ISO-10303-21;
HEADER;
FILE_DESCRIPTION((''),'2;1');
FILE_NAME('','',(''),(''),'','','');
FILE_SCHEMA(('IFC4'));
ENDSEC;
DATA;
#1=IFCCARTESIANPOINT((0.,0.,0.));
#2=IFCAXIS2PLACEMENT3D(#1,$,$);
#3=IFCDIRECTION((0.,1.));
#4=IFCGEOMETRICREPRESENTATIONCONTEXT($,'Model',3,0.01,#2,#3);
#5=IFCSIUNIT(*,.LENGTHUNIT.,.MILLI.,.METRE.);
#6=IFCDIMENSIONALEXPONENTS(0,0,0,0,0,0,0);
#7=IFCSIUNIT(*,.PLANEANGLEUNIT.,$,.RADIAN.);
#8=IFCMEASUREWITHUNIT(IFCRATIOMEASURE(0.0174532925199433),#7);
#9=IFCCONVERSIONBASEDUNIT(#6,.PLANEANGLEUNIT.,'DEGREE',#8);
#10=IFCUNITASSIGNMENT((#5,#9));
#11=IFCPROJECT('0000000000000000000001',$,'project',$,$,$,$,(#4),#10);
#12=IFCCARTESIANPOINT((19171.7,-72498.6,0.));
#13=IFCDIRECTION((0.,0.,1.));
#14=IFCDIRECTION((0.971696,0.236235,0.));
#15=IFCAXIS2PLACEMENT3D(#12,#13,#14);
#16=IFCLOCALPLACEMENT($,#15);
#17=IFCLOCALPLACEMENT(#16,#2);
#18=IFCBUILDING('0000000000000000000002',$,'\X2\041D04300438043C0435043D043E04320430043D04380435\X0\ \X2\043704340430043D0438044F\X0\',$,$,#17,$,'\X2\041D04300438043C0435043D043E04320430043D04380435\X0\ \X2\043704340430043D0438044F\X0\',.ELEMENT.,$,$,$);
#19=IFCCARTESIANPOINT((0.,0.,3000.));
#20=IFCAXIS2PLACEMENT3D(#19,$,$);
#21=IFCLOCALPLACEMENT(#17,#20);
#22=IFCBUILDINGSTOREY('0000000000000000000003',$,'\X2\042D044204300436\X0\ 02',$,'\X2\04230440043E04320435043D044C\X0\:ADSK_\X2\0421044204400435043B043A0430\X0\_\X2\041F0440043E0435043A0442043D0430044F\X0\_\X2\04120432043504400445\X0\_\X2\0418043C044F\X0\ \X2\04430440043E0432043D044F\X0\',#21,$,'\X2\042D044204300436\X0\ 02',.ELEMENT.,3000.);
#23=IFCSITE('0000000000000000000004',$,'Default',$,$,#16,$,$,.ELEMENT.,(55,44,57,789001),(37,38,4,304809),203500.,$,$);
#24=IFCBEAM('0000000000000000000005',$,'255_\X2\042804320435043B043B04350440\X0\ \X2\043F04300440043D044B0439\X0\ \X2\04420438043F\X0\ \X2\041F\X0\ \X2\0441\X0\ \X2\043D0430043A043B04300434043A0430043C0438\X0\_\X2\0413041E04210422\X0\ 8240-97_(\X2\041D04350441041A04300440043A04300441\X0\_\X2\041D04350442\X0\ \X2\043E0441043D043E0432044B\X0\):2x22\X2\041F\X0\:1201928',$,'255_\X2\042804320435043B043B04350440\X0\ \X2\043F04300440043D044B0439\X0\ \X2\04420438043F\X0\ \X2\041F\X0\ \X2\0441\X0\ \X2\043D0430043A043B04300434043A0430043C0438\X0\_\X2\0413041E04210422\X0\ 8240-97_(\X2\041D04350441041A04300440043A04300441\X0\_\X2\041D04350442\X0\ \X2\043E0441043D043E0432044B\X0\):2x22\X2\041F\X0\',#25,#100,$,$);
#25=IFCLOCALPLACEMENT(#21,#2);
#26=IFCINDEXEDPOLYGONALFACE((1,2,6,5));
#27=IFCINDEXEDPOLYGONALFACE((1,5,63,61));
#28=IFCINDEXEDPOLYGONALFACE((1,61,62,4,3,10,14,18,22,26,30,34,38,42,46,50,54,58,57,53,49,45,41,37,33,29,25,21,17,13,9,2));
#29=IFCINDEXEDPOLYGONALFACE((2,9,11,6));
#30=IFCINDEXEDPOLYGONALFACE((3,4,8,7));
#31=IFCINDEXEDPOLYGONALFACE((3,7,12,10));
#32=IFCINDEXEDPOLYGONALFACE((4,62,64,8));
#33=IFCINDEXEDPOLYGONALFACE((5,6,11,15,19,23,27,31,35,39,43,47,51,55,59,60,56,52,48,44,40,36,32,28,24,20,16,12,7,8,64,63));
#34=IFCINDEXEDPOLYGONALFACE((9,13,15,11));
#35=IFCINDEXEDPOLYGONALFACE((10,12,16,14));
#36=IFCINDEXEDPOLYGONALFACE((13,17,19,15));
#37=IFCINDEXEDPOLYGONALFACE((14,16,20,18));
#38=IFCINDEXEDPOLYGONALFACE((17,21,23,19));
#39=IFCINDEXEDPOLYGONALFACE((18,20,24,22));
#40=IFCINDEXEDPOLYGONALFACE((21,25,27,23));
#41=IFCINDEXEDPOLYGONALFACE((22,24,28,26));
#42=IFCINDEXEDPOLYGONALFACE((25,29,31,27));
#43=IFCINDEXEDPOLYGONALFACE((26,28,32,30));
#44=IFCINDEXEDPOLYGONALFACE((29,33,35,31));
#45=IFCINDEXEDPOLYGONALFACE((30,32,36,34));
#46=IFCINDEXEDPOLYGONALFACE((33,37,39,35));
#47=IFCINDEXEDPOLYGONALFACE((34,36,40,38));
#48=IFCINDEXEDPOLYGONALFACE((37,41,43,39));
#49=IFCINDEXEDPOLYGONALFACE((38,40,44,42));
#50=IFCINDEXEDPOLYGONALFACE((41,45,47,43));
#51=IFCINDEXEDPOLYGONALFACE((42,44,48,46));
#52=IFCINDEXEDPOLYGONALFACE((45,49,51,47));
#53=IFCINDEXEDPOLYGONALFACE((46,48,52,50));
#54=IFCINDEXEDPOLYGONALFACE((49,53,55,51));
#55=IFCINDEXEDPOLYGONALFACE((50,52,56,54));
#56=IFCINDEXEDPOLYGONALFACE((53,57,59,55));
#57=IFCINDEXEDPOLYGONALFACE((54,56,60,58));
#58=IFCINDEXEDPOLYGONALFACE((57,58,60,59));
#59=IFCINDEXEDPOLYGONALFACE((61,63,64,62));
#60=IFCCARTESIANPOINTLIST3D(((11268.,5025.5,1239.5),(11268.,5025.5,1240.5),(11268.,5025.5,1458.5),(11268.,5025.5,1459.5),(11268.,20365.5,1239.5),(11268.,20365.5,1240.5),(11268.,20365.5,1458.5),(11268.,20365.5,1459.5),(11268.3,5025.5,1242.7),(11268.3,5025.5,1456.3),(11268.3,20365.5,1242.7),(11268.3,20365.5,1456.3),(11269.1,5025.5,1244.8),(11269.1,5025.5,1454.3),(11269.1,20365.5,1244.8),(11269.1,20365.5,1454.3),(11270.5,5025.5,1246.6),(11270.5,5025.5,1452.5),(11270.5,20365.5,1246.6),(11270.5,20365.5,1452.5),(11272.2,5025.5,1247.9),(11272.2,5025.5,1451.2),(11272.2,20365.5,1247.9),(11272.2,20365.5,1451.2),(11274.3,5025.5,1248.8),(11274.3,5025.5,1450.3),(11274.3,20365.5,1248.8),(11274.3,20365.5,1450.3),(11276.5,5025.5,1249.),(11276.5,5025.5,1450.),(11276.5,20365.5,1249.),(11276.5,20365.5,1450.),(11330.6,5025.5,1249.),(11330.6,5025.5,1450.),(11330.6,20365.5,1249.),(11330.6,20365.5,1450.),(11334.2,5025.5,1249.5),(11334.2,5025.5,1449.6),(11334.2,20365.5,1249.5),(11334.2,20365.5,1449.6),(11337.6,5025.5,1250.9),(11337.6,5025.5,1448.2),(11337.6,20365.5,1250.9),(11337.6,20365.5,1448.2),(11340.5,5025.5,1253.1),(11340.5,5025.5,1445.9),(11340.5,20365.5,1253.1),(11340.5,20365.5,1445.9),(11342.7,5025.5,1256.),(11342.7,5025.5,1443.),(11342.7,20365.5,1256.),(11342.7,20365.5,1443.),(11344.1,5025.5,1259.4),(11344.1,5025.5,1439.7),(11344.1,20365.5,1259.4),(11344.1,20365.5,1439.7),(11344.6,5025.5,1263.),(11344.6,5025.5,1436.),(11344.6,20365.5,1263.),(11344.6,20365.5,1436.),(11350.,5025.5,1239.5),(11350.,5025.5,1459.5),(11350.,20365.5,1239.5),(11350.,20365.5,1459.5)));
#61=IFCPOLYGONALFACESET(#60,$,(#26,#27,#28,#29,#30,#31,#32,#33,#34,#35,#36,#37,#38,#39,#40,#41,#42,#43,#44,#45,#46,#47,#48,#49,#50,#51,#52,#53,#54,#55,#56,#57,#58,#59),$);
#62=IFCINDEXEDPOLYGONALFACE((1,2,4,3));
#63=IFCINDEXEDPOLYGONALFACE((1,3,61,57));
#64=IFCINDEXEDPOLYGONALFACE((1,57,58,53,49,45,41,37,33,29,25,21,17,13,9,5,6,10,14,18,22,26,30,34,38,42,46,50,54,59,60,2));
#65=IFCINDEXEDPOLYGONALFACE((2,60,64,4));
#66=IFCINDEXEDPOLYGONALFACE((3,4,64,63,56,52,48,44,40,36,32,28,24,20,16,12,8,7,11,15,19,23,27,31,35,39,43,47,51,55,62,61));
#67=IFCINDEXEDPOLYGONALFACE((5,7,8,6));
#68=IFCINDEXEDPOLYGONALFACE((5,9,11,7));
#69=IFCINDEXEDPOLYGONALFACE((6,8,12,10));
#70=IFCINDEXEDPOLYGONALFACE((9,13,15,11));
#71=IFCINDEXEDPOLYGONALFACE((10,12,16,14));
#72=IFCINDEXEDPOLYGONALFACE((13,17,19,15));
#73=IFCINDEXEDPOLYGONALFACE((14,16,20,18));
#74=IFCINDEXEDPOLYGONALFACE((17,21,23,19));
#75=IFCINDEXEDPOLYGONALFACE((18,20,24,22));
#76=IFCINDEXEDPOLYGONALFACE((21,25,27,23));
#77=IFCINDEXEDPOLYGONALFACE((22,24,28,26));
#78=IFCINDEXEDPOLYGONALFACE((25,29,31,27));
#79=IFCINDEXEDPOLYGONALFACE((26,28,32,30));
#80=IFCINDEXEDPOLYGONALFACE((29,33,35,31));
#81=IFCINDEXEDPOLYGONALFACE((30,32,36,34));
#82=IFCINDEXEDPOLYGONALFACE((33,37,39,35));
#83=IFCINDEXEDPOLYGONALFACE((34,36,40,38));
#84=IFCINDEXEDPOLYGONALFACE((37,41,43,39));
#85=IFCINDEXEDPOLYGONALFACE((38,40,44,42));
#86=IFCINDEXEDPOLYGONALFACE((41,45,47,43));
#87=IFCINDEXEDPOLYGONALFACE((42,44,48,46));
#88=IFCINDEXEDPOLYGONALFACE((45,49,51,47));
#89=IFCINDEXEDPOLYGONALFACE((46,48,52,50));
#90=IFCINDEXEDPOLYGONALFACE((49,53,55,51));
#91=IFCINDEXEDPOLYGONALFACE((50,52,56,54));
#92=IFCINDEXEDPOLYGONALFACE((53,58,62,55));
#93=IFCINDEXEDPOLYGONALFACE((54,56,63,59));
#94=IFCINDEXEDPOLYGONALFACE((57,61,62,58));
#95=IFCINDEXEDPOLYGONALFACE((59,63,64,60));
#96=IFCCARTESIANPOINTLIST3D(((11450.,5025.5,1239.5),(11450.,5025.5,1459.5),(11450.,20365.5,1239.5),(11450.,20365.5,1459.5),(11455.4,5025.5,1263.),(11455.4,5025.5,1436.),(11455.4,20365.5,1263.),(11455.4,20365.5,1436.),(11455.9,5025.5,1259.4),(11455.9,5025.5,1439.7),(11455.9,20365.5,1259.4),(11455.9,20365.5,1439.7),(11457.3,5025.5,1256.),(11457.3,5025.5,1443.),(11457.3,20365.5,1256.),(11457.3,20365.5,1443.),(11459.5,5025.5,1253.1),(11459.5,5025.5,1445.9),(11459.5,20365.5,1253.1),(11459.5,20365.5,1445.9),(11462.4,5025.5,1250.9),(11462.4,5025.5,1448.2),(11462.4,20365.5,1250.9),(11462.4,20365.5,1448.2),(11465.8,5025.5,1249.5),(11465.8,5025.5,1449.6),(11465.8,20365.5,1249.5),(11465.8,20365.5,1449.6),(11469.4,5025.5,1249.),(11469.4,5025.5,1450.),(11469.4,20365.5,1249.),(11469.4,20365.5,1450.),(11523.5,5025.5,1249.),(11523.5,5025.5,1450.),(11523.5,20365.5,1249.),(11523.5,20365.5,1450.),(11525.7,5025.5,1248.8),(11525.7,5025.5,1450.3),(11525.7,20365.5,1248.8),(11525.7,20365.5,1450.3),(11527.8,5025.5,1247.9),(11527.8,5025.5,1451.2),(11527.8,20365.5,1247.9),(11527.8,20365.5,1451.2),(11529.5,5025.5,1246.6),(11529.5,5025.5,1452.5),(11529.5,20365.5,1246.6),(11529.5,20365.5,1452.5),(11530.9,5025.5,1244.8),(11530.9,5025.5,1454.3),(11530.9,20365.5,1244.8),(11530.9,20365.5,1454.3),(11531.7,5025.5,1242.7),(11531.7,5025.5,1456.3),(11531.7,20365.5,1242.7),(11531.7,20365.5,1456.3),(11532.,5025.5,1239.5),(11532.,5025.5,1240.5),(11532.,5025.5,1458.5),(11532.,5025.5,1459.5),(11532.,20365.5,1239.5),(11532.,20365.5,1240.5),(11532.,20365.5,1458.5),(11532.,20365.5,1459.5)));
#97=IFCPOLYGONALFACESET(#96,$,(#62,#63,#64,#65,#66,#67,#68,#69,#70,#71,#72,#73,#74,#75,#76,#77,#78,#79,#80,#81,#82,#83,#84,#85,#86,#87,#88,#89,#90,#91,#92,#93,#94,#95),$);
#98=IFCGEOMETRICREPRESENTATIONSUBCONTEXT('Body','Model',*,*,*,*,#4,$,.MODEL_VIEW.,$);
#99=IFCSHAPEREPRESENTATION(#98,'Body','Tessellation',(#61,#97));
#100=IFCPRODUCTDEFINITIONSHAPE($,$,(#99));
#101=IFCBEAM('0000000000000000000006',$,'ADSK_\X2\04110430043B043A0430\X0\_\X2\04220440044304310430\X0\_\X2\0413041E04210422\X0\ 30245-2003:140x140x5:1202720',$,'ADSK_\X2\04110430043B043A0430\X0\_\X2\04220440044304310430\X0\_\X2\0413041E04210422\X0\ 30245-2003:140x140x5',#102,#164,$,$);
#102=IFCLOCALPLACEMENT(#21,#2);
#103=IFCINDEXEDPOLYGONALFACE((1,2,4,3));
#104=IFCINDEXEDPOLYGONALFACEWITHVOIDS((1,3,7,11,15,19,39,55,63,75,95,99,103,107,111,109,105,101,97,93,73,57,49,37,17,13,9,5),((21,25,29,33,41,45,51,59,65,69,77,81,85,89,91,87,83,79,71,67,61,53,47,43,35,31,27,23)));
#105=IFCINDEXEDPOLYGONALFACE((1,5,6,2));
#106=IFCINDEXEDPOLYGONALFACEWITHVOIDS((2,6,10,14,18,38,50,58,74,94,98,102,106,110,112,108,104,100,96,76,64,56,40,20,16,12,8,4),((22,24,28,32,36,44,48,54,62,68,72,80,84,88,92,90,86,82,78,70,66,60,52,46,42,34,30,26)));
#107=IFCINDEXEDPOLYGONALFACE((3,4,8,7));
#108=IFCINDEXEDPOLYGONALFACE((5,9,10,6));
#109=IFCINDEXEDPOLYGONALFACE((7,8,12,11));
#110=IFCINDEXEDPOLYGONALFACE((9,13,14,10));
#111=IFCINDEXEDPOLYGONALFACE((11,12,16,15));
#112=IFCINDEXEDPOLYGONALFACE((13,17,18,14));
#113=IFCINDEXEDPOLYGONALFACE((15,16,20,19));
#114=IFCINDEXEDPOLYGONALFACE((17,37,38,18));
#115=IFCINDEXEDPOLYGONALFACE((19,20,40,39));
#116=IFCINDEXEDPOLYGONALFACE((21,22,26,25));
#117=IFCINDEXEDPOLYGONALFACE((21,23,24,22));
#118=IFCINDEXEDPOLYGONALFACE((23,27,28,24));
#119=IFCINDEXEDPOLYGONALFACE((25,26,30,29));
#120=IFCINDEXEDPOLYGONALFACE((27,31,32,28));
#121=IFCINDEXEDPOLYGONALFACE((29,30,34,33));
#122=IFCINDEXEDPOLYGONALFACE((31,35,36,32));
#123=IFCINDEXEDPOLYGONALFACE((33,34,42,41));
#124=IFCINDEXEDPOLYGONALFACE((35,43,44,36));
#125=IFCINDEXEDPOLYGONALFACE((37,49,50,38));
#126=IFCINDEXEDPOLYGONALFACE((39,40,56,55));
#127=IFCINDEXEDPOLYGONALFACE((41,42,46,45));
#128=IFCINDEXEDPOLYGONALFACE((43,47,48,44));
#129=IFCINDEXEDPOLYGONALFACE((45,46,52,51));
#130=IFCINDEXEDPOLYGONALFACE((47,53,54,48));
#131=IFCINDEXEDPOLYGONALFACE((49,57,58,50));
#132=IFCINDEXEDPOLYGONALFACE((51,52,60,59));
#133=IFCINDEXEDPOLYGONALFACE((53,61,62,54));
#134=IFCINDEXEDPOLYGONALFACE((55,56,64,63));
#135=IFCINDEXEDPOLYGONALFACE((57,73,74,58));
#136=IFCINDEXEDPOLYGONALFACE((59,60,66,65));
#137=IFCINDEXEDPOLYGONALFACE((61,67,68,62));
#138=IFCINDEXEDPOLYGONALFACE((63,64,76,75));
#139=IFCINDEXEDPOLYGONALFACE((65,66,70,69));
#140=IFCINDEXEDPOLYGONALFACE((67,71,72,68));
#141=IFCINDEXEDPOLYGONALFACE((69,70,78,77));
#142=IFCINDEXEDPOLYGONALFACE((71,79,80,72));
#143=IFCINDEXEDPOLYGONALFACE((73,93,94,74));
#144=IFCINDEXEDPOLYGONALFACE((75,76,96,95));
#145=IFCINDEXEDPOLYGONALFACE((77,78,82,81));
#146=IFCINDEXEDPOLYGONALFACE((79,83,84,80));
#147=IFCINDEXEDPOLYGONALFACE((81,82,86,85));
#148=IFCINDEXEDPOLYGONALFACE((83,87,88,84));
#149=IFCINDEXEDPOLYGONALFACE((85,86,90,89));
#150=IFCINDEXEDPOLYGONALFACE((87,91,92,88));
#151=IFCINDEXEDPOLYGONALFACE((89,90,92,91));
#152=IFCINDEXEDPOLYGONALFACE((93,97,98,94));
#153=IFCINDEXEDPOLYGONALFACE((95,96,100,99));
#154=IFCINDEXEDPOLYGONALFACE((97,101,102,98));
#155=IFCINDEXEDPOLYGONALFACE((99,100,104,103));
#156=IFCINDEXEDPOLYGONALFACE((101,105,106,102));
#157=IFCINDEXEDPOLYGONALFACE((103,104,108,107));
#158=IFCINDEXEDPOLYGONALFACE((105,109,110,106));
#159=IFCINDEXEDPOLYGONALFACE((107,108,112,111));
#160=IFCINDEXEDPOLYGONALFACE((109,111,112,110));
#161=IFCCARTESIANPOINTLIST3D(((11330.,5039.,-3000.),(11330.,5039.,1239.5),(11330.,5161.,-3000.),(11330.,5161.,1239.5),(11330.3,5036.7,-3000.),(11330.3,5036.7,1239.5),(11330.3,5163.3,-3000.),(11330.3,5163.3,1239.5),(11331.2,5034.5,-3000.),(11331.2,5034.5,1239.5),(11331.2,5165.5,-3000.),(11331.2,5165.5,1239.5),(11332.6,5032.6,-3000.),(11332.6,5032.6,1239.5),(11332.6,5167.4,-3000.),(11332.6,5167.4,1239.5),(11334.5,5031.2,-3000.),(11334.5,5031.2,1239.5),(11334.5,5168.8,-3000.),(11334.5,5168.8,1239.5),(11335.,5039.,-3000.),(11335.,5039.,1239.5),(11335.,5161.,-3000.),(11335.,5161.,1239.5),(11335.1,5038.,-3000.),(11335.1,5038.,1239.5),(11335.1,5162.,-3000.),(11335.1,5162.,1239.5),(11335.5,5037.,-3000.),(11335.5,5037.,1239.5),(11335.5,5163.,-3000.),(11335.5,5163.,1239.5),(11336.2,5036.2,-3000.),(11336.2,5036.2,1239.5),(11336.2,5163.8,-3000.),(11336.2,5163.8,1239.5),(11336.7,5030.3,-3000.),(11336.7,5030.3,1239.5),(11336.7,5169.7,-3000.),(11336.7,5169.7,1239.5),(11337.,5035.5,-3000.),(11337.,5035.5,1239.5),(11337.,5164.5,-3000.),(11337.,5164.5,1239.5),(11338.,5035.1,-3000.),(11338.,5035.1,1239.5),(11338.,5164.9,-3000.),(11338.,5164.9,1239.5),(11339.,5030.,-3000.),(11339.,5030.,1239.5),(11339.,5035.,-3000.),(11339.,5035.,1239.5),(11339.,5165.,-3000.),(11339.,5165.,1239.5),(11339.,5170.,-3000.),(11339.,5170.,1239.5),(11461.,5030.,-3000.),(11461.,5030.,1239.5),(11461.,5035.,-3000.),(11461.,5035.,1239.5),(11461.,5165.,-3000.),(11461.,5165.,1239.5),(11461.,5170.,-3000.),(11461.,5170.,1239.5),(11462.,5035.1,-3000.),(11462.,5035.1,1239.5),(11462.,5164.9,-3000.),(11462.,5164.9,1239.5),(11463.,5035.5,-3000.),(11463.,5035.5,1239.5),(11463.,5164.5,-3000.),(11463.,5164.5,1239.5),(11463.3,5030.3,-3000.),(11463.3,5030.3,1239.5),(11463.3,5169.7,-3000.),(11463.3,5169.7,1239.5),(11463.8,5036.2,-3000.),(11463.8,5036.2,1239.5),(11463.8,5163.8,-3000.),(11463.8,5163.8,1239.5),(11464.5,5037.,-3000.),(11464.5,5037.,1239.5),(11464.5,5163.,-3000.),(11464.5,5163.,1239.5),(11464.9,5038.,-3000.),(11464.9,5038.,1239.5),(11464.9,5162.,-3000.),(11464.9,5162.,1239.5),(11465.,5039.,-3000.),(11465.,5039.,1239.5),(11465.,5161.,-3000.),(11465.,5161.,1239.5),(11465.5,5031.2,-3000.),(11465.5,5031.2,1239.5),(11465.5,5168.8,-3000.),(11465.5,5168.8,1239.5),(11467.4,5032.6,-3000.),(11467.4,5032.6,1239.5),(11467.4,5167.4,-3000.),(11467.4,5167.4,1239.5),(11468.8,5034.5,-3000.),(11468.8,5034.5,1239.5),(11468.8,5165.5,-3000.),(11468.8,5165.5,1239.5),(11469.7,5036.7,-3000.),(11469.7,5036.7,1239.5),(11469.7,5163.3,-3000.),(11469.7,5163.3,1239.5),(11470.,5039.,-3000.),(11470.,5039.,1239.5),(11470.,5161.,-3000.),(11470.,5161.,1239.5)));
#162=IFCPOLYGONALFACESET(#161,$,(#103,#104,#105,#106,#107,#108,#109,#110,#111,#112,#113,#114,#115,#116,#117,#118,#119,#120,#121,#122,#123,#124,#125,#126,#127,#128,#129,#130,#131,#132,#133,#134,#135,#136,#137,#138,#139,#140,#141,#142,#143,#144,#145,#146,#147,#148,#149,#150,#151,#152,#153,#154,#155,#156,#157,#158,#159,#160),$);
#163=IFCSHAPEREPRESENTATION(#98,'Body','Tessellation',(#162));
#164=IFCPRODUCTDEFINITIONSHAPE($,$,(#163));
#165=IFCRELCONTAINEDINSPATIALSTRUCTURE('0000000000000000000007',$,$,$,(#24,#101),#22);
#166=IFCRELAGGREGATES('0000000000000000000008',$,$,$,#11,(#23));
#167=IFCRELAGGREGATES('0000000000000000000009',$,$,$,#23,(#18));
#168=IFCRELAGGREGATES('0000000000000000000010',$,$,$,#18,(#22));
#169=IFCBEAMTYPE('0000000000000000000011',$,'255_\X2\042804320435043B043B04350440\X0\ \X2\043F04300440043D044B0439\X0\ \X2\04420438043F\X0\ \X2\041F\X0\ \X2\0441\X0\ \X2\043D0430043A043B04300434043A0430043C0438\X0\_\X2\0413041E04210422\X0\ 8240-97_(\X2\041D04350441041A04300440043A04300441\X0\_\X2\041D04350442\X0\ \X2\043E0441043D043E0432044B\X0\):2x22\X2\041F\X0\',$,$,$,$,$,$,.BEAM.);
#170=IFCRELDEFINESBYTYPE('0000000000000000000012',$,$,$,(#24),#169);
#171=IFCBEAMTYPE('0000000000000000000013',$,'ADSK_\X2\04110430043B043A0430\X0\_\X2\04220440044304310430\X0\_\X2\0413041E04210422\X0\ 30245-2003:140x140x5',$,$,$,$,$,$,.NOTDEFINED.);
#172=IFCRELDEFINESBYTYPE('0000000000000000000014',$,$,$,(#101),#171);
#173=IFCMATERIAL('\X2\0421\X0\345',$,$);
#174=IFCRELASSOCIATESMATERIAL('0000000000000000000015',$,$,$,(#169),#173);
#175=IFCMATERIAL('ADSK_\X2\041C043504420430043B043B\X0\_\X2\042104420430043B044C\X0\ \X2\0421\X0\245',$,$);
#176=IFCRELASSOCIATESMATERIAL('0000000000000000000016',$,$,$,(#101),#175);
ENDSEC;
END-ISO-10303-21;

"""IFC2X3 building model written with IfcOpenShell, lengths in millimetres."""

from ifc_helpers import new_model, entity, si_unit, converted_unit, direction, frame, frame_2d, origin, place, context, subcontext, project, spatial, polyline, circle_curve, parameter, trimmed, segment, composite_curve, outline, extrude, source, transform, mapped, material, type_object, type_shapes, element, save


model = new_model("IFC2X3")

# Units and contexts
model_context = context("Model", 3, precision=0.01, world=origin(), true_north=direction((0.0, 1.0)))
body_context = subcontext(model_context, "Body", "Model", "MODEL_VIEW")
ifc_project = project(units=[si_unit("LENGTHUNIT", "METRE", prefix="MILLI"), converted_unit("PLANEANGLEUNIT", "DEGREE", entity("IfcRatioMeasure", 0.0174532925199433), si_unit("PLANEANGLEUNIT", "RADIAN"), dimensions=[0, 0, 0, 0, 0, 0, 0])], contexts=[model_context])

# Site, building, storey
site_placement = place(None, frame((19171.7, -72498.6, 0.0), z_axis=(0.0, 0.0, 1.0), x_axis=(0.971696, 0.236235, 0.0)))
site = spatial("IfcSite", under=ifc_project, at=site_placement, Name="Default", CompositionType="ELEMENT", RefLatitude=(55, 44, 57, 789001), RefLongitude=(37, 38, 4, 304809), RefElevation=203500.0)
building_placement = place(site_placement, origin())
building = spatial("IfcBuilding", under=site, at=building_placement, Name="Наименование здания", LongName="Наименование здания", CompositionType="ELEMENT")
storey_placement = place(building_placement, frame((0.0, 0.0, 3000.0)))
storey = spatial("IfcBuildingStorey", under=building, at=storey_placement, Name="Этаж 02", ObjectType="Уровень:ADSK_Стрелка_Проектная_Вверх_Имя уровня", LongName="Этаж 02", CompositionType="ELEMENT", Elevation=3000.0)

# Beams
ifc_material_1 = material(Name="С345")
beam_type_1 = type_object("IfcBeamType", Name="255_Швеллер парный тип П с накладками_ГОСТ 8240-97_(НесКаркас_Нет основы):2x22П", PredefinedType="BEAM", material=ifc_material_1)
shared_shape_1 = source(origin(), body_context, "Body", "SweptSolid", [
    extrude(outline(composite_curve([segment(polyline([(-110.0, -43.7), (110.0, -43.7)]), True, "CONTINUOUS"), segment(polyline([(110.0, -43.7), (110.0, 38.3)]), True, "CONTINUOUS"), segment(polyline([(110.0, 38.3), (109.0, 38.3)]), True, "CONTINUOUS"), segment(trimmed(circle_curve(frame_2d((109.0, 29.8), x_axis=(0.0, 1.0)), 8.5), [parameter(0.0)], [parameter(90.0)], True, "PARAMETER"), True, "CONTINUOUS"), segment(polyline([(100.5, 29.8), (100.5, -24.3)]), True, "CONTINUOUS"), segment(trimmed(circle_curve(frame_2d((86.5, -24.3), x_axis=(1.0, 0.0)), 14.0), [parameter(270.0)], [parameter(0.0)], True, "PARAMETER"), False, "CONTINUOUS"), segment(polyline([(86.5, -38.3), (-86.5, -38.3)]), True, "CONTINUOUS"), segment(trimmed(circle_curve(frame_2d((-86.5, -24.3), x_axis=(0.0, -1.0)), 14.0), [parameter(270.0)], [parameter(0.0)], True, "PARAMETER"), False, "CONTINUOUS"), segment(polyline([(-100.5, -24.3), (-100.5, 29.8)]), True, "CONTINUOUS"), segment(trimmed(circle_curve(frame_2d((-109.0, 29.8), x_axis=(1.0, 0.0)), 8.5), [parameter(0.0)], [parameter(90.0)], True, "PARAMETER"), True, "CONTINUOUS"), segment(polyline([(-109.0, 38.3), (-110.0, 38.3)]), True, "CONTINUOUS"), segment(polyline([(-110.0, 38.3), (-110.0, -43.7)]), True, "CONTINUOUS")], self_intersect=False)), frame((-7670.0, 93.7, 0.0), z_axis=(1.0, 0.0, 0.0), x_axis=(0.0, 0.0, -1.0)), (0.0, 0.0, 1.0), 15340.0),
    extrude(outline(composite_curve([segment(polyline([(-110.0, -38.3), (-109.0, -38.3)]), True, "CONTINUOUS"), segment(trimmed(circle_curve(frame_2d((-109.0, -29.8), x_axis=(0.0, -1.0)), 8.5), [parameter(0.0)], [parameter(90.0)], True, "PARAMETER"), True, "CONTINUOUS"), segment(polyline([(-100.5, -29.8), (-100.5, 24.3)]), True, "CONTINUOUS"), segment(trimmed(circle_curve(frame_2d((-86.5, 24.3), x_axis=(-1.0, 0.0)), 14.0), [parameter(270.0)], [parameter(0.0)], True, "PARAMETER"), False, "CONTINUOUS"), segment(polyline([(-86.5, 38.3), (86.5, 38.3)]), True, "CONTINUOUS"), segment(trimmed(circle_curve(frame_2d((86.5, 24.3), x_axis=(0.0, 1.0)), 14.0), [parameter(270.0)], [parameter(0.0)], True, "PARAMETER"), False, "CONTINUOUS"), segment(polyline([(100.5, 24.3), (100.5, -29.8)]), True, "CONTINUOUS"), segment(trimmed(circle_curve(frame_2d((109.0, -29.8), x_axis=(-1.0, 0.0)), 8.5), [parameter(0.0)], [parameter(90.0)], True, "PARAMETER"), True, "CONTINUOUS"), segment(polyline([(109.0, -38.3), (110.0, -38.3)]), True, "CONTINUOUS"), segment(polyline([(110.0, -38.3), (110.0, 43.7)]), True, "CONTINUOUS"), segment(polyline([(110.0, 43.7), (-110.0, 43.7)]), True, "CONTINUOUS"), segment(polyline([(-110.0, 43.7), (-110.0, -38.3)]), True, "CONTINUOUS")], self_intersect=False)), frame((-7670.0, -93.7, 0.0), z_axis=(1.0, 0.0, 0.0), x_axis=(0.0, 0.0, -1.0)), (0.0, 0.0, 1.0), 15340.0),
])
type_shapes(beam_type_1, [shared_shape_1])
beam_1_placement = place(storey_placement, frame((11400.0, 12695.5, 1349.5), z_axis=(0.0, 0.0, 1.0), x_axis=(0.0, 1.0, 0.0)))
element("IfcBeam", 1, at=beam_1_placement, inside=storey, type_object=beam_type_1, Name="255_Швеллер парный тип П с накладками_ГОСТ 8240-97_(НесКаркас_Нет основы):2x22П:1201928", ObjectType="255_Швеллер парный тип П с накладками_ГОСТ 8240-97_(НесКаркас_Нет основы):2x22П", context=body_context, shape_type="MappedRepresentation", body=[
    mapped(shared_shape_1, transform((0.0, 0.0, 0.0), scale=1.0)),
])
ifc_material_2 = material(Name="ADSK_Металл_Сталь С245")
beam_type_2 = type_object("IfcBeamType", Name="ADSK_Балка_Труба_ГОСТ 30245-2003:140x140x5", PredefinedType="NOTDEFINED")
beam_2_placement = place(storey_placement, frame((11328.4, 5028.4, -3000.0), z_axis=(1.0, 0.0, 0.0), x_axis=(0.0, 0.0, -1.0)))
element("IfcBeam", 2, at=beam_2_placement, inside=storey, type_object=beam_type_2, material=ifc_material_2, Name="ADSK_Балка_Труба_ГОСТ 30245-2003:140x140x5:1202720", ObjectType="ADSK_Балка_Труба_ГОСТ 30245-2003:140x140x5", context=body_context, shape_type="SweptSolid", body=[
    extrude(outline(composite_curve([segment(trimmed(circle_curve(frame_2d((61.0, -61.0), x_axis=(1.0, 0.0)), 9.0), [parameter(270.0)], [parameter(0.0)], True, "PARAMETER"), True, "CONTINUOUS"), segment(polyline([(70.0, -61.0), (70.0, 61.0)]), True, "CONTINUOUS"), segment(trimmed(circle_curve(frame_2d((61.0, 61.0), x_axis=(1.0, 0.0)), 9.0), [parameter(0.0)], [parameter(90.0)], True, "PARAMETER"), True, "CONTINUOUS"), segment(polyline([(61.0, 70.0), (-61.0, 70.0)]), True, "CONTINUOUS"), segment(trimmed(circle_curve(frame_2d((-61.0, 61.0), x_axis=(1.0, 0.0)), 9.0), [parameter(90.0)], [parameter(180.0)], True, "PARAMETER"), True, "CONTINUOUS"), segment(polyline([(-70.0, 61.0), (-70.0, -61.0)]), True, "CONTINUOUS"), segment(trimmed(circle_curve(frame_2d((-61.0, -61.0), x_axis=(1.0, 0.0)), 9.0), [parameter(180.0)], [parameter(270.0)], True, "PARAMETER"), True, "CONTINUOUS"), segment(polyline([(-61.0, -70.0), (61.0, -70.0)]), True, "CONTINUOUS")], self_intersect=False), holes=[composite_curve([segment(polyline([(61.0, -65.0), (-61.0, -65.0)]), True, "CONTINUOUS"), segment(trimmed(circle_curve(frame_2d((-61.0, -61.0), x_axis=(1.0, 0.0)), 4.0), [parameter(180.0)], [parameter(270.0)], True, "PARAMETER"), False, "CONTINUOUS"), segment(polyline([(-65.0, -61.0), (-65.0, 61.0)]), True, "CONTINUOUS"), segment(trimmed(circle_curve(frame_2d((-61.0, 61.0), x_axis=(1.0, 0.0)), 4.0), [parameter(90.0)], [parameter(180.0)], True, "PARAMETER"), False, "CONTINUOUS"), segment(polyline([(-61.0, 65.0), (61.0, 65.0)]), True, "CONTINUOUS"), segment(trimmed(circle_curve(frame_2d((61.0, 61.0), x_axis=(1.0, 0.0)), 4.0), [parameter(0.0)], [parameter(90.0)], True, "PARAMETER"), False, "CONTINUOUS"), segment(polyline([(65.0, 61.0), (65.0, -61.0)]), True, "CONTINUOUS"), segment(trimmed(circle_curve(frame_2d((61.0, -61.0), x_axis=(1.0, 0.0)), 4.0), [parameter(270.0)], [parameter(0.0)], True, "PARAMETER"), False, "CONTINUOUS")], self_intersect=False)]), frame((-4239.5, 71.6, 71.6), z_axis=(1.0, 0.0, 0.0), x_axis=(0.0, 0.0, 1.0)), (0.0, 0.0, 1.0), 4239.5),
])

save(model, "model.ifc")
